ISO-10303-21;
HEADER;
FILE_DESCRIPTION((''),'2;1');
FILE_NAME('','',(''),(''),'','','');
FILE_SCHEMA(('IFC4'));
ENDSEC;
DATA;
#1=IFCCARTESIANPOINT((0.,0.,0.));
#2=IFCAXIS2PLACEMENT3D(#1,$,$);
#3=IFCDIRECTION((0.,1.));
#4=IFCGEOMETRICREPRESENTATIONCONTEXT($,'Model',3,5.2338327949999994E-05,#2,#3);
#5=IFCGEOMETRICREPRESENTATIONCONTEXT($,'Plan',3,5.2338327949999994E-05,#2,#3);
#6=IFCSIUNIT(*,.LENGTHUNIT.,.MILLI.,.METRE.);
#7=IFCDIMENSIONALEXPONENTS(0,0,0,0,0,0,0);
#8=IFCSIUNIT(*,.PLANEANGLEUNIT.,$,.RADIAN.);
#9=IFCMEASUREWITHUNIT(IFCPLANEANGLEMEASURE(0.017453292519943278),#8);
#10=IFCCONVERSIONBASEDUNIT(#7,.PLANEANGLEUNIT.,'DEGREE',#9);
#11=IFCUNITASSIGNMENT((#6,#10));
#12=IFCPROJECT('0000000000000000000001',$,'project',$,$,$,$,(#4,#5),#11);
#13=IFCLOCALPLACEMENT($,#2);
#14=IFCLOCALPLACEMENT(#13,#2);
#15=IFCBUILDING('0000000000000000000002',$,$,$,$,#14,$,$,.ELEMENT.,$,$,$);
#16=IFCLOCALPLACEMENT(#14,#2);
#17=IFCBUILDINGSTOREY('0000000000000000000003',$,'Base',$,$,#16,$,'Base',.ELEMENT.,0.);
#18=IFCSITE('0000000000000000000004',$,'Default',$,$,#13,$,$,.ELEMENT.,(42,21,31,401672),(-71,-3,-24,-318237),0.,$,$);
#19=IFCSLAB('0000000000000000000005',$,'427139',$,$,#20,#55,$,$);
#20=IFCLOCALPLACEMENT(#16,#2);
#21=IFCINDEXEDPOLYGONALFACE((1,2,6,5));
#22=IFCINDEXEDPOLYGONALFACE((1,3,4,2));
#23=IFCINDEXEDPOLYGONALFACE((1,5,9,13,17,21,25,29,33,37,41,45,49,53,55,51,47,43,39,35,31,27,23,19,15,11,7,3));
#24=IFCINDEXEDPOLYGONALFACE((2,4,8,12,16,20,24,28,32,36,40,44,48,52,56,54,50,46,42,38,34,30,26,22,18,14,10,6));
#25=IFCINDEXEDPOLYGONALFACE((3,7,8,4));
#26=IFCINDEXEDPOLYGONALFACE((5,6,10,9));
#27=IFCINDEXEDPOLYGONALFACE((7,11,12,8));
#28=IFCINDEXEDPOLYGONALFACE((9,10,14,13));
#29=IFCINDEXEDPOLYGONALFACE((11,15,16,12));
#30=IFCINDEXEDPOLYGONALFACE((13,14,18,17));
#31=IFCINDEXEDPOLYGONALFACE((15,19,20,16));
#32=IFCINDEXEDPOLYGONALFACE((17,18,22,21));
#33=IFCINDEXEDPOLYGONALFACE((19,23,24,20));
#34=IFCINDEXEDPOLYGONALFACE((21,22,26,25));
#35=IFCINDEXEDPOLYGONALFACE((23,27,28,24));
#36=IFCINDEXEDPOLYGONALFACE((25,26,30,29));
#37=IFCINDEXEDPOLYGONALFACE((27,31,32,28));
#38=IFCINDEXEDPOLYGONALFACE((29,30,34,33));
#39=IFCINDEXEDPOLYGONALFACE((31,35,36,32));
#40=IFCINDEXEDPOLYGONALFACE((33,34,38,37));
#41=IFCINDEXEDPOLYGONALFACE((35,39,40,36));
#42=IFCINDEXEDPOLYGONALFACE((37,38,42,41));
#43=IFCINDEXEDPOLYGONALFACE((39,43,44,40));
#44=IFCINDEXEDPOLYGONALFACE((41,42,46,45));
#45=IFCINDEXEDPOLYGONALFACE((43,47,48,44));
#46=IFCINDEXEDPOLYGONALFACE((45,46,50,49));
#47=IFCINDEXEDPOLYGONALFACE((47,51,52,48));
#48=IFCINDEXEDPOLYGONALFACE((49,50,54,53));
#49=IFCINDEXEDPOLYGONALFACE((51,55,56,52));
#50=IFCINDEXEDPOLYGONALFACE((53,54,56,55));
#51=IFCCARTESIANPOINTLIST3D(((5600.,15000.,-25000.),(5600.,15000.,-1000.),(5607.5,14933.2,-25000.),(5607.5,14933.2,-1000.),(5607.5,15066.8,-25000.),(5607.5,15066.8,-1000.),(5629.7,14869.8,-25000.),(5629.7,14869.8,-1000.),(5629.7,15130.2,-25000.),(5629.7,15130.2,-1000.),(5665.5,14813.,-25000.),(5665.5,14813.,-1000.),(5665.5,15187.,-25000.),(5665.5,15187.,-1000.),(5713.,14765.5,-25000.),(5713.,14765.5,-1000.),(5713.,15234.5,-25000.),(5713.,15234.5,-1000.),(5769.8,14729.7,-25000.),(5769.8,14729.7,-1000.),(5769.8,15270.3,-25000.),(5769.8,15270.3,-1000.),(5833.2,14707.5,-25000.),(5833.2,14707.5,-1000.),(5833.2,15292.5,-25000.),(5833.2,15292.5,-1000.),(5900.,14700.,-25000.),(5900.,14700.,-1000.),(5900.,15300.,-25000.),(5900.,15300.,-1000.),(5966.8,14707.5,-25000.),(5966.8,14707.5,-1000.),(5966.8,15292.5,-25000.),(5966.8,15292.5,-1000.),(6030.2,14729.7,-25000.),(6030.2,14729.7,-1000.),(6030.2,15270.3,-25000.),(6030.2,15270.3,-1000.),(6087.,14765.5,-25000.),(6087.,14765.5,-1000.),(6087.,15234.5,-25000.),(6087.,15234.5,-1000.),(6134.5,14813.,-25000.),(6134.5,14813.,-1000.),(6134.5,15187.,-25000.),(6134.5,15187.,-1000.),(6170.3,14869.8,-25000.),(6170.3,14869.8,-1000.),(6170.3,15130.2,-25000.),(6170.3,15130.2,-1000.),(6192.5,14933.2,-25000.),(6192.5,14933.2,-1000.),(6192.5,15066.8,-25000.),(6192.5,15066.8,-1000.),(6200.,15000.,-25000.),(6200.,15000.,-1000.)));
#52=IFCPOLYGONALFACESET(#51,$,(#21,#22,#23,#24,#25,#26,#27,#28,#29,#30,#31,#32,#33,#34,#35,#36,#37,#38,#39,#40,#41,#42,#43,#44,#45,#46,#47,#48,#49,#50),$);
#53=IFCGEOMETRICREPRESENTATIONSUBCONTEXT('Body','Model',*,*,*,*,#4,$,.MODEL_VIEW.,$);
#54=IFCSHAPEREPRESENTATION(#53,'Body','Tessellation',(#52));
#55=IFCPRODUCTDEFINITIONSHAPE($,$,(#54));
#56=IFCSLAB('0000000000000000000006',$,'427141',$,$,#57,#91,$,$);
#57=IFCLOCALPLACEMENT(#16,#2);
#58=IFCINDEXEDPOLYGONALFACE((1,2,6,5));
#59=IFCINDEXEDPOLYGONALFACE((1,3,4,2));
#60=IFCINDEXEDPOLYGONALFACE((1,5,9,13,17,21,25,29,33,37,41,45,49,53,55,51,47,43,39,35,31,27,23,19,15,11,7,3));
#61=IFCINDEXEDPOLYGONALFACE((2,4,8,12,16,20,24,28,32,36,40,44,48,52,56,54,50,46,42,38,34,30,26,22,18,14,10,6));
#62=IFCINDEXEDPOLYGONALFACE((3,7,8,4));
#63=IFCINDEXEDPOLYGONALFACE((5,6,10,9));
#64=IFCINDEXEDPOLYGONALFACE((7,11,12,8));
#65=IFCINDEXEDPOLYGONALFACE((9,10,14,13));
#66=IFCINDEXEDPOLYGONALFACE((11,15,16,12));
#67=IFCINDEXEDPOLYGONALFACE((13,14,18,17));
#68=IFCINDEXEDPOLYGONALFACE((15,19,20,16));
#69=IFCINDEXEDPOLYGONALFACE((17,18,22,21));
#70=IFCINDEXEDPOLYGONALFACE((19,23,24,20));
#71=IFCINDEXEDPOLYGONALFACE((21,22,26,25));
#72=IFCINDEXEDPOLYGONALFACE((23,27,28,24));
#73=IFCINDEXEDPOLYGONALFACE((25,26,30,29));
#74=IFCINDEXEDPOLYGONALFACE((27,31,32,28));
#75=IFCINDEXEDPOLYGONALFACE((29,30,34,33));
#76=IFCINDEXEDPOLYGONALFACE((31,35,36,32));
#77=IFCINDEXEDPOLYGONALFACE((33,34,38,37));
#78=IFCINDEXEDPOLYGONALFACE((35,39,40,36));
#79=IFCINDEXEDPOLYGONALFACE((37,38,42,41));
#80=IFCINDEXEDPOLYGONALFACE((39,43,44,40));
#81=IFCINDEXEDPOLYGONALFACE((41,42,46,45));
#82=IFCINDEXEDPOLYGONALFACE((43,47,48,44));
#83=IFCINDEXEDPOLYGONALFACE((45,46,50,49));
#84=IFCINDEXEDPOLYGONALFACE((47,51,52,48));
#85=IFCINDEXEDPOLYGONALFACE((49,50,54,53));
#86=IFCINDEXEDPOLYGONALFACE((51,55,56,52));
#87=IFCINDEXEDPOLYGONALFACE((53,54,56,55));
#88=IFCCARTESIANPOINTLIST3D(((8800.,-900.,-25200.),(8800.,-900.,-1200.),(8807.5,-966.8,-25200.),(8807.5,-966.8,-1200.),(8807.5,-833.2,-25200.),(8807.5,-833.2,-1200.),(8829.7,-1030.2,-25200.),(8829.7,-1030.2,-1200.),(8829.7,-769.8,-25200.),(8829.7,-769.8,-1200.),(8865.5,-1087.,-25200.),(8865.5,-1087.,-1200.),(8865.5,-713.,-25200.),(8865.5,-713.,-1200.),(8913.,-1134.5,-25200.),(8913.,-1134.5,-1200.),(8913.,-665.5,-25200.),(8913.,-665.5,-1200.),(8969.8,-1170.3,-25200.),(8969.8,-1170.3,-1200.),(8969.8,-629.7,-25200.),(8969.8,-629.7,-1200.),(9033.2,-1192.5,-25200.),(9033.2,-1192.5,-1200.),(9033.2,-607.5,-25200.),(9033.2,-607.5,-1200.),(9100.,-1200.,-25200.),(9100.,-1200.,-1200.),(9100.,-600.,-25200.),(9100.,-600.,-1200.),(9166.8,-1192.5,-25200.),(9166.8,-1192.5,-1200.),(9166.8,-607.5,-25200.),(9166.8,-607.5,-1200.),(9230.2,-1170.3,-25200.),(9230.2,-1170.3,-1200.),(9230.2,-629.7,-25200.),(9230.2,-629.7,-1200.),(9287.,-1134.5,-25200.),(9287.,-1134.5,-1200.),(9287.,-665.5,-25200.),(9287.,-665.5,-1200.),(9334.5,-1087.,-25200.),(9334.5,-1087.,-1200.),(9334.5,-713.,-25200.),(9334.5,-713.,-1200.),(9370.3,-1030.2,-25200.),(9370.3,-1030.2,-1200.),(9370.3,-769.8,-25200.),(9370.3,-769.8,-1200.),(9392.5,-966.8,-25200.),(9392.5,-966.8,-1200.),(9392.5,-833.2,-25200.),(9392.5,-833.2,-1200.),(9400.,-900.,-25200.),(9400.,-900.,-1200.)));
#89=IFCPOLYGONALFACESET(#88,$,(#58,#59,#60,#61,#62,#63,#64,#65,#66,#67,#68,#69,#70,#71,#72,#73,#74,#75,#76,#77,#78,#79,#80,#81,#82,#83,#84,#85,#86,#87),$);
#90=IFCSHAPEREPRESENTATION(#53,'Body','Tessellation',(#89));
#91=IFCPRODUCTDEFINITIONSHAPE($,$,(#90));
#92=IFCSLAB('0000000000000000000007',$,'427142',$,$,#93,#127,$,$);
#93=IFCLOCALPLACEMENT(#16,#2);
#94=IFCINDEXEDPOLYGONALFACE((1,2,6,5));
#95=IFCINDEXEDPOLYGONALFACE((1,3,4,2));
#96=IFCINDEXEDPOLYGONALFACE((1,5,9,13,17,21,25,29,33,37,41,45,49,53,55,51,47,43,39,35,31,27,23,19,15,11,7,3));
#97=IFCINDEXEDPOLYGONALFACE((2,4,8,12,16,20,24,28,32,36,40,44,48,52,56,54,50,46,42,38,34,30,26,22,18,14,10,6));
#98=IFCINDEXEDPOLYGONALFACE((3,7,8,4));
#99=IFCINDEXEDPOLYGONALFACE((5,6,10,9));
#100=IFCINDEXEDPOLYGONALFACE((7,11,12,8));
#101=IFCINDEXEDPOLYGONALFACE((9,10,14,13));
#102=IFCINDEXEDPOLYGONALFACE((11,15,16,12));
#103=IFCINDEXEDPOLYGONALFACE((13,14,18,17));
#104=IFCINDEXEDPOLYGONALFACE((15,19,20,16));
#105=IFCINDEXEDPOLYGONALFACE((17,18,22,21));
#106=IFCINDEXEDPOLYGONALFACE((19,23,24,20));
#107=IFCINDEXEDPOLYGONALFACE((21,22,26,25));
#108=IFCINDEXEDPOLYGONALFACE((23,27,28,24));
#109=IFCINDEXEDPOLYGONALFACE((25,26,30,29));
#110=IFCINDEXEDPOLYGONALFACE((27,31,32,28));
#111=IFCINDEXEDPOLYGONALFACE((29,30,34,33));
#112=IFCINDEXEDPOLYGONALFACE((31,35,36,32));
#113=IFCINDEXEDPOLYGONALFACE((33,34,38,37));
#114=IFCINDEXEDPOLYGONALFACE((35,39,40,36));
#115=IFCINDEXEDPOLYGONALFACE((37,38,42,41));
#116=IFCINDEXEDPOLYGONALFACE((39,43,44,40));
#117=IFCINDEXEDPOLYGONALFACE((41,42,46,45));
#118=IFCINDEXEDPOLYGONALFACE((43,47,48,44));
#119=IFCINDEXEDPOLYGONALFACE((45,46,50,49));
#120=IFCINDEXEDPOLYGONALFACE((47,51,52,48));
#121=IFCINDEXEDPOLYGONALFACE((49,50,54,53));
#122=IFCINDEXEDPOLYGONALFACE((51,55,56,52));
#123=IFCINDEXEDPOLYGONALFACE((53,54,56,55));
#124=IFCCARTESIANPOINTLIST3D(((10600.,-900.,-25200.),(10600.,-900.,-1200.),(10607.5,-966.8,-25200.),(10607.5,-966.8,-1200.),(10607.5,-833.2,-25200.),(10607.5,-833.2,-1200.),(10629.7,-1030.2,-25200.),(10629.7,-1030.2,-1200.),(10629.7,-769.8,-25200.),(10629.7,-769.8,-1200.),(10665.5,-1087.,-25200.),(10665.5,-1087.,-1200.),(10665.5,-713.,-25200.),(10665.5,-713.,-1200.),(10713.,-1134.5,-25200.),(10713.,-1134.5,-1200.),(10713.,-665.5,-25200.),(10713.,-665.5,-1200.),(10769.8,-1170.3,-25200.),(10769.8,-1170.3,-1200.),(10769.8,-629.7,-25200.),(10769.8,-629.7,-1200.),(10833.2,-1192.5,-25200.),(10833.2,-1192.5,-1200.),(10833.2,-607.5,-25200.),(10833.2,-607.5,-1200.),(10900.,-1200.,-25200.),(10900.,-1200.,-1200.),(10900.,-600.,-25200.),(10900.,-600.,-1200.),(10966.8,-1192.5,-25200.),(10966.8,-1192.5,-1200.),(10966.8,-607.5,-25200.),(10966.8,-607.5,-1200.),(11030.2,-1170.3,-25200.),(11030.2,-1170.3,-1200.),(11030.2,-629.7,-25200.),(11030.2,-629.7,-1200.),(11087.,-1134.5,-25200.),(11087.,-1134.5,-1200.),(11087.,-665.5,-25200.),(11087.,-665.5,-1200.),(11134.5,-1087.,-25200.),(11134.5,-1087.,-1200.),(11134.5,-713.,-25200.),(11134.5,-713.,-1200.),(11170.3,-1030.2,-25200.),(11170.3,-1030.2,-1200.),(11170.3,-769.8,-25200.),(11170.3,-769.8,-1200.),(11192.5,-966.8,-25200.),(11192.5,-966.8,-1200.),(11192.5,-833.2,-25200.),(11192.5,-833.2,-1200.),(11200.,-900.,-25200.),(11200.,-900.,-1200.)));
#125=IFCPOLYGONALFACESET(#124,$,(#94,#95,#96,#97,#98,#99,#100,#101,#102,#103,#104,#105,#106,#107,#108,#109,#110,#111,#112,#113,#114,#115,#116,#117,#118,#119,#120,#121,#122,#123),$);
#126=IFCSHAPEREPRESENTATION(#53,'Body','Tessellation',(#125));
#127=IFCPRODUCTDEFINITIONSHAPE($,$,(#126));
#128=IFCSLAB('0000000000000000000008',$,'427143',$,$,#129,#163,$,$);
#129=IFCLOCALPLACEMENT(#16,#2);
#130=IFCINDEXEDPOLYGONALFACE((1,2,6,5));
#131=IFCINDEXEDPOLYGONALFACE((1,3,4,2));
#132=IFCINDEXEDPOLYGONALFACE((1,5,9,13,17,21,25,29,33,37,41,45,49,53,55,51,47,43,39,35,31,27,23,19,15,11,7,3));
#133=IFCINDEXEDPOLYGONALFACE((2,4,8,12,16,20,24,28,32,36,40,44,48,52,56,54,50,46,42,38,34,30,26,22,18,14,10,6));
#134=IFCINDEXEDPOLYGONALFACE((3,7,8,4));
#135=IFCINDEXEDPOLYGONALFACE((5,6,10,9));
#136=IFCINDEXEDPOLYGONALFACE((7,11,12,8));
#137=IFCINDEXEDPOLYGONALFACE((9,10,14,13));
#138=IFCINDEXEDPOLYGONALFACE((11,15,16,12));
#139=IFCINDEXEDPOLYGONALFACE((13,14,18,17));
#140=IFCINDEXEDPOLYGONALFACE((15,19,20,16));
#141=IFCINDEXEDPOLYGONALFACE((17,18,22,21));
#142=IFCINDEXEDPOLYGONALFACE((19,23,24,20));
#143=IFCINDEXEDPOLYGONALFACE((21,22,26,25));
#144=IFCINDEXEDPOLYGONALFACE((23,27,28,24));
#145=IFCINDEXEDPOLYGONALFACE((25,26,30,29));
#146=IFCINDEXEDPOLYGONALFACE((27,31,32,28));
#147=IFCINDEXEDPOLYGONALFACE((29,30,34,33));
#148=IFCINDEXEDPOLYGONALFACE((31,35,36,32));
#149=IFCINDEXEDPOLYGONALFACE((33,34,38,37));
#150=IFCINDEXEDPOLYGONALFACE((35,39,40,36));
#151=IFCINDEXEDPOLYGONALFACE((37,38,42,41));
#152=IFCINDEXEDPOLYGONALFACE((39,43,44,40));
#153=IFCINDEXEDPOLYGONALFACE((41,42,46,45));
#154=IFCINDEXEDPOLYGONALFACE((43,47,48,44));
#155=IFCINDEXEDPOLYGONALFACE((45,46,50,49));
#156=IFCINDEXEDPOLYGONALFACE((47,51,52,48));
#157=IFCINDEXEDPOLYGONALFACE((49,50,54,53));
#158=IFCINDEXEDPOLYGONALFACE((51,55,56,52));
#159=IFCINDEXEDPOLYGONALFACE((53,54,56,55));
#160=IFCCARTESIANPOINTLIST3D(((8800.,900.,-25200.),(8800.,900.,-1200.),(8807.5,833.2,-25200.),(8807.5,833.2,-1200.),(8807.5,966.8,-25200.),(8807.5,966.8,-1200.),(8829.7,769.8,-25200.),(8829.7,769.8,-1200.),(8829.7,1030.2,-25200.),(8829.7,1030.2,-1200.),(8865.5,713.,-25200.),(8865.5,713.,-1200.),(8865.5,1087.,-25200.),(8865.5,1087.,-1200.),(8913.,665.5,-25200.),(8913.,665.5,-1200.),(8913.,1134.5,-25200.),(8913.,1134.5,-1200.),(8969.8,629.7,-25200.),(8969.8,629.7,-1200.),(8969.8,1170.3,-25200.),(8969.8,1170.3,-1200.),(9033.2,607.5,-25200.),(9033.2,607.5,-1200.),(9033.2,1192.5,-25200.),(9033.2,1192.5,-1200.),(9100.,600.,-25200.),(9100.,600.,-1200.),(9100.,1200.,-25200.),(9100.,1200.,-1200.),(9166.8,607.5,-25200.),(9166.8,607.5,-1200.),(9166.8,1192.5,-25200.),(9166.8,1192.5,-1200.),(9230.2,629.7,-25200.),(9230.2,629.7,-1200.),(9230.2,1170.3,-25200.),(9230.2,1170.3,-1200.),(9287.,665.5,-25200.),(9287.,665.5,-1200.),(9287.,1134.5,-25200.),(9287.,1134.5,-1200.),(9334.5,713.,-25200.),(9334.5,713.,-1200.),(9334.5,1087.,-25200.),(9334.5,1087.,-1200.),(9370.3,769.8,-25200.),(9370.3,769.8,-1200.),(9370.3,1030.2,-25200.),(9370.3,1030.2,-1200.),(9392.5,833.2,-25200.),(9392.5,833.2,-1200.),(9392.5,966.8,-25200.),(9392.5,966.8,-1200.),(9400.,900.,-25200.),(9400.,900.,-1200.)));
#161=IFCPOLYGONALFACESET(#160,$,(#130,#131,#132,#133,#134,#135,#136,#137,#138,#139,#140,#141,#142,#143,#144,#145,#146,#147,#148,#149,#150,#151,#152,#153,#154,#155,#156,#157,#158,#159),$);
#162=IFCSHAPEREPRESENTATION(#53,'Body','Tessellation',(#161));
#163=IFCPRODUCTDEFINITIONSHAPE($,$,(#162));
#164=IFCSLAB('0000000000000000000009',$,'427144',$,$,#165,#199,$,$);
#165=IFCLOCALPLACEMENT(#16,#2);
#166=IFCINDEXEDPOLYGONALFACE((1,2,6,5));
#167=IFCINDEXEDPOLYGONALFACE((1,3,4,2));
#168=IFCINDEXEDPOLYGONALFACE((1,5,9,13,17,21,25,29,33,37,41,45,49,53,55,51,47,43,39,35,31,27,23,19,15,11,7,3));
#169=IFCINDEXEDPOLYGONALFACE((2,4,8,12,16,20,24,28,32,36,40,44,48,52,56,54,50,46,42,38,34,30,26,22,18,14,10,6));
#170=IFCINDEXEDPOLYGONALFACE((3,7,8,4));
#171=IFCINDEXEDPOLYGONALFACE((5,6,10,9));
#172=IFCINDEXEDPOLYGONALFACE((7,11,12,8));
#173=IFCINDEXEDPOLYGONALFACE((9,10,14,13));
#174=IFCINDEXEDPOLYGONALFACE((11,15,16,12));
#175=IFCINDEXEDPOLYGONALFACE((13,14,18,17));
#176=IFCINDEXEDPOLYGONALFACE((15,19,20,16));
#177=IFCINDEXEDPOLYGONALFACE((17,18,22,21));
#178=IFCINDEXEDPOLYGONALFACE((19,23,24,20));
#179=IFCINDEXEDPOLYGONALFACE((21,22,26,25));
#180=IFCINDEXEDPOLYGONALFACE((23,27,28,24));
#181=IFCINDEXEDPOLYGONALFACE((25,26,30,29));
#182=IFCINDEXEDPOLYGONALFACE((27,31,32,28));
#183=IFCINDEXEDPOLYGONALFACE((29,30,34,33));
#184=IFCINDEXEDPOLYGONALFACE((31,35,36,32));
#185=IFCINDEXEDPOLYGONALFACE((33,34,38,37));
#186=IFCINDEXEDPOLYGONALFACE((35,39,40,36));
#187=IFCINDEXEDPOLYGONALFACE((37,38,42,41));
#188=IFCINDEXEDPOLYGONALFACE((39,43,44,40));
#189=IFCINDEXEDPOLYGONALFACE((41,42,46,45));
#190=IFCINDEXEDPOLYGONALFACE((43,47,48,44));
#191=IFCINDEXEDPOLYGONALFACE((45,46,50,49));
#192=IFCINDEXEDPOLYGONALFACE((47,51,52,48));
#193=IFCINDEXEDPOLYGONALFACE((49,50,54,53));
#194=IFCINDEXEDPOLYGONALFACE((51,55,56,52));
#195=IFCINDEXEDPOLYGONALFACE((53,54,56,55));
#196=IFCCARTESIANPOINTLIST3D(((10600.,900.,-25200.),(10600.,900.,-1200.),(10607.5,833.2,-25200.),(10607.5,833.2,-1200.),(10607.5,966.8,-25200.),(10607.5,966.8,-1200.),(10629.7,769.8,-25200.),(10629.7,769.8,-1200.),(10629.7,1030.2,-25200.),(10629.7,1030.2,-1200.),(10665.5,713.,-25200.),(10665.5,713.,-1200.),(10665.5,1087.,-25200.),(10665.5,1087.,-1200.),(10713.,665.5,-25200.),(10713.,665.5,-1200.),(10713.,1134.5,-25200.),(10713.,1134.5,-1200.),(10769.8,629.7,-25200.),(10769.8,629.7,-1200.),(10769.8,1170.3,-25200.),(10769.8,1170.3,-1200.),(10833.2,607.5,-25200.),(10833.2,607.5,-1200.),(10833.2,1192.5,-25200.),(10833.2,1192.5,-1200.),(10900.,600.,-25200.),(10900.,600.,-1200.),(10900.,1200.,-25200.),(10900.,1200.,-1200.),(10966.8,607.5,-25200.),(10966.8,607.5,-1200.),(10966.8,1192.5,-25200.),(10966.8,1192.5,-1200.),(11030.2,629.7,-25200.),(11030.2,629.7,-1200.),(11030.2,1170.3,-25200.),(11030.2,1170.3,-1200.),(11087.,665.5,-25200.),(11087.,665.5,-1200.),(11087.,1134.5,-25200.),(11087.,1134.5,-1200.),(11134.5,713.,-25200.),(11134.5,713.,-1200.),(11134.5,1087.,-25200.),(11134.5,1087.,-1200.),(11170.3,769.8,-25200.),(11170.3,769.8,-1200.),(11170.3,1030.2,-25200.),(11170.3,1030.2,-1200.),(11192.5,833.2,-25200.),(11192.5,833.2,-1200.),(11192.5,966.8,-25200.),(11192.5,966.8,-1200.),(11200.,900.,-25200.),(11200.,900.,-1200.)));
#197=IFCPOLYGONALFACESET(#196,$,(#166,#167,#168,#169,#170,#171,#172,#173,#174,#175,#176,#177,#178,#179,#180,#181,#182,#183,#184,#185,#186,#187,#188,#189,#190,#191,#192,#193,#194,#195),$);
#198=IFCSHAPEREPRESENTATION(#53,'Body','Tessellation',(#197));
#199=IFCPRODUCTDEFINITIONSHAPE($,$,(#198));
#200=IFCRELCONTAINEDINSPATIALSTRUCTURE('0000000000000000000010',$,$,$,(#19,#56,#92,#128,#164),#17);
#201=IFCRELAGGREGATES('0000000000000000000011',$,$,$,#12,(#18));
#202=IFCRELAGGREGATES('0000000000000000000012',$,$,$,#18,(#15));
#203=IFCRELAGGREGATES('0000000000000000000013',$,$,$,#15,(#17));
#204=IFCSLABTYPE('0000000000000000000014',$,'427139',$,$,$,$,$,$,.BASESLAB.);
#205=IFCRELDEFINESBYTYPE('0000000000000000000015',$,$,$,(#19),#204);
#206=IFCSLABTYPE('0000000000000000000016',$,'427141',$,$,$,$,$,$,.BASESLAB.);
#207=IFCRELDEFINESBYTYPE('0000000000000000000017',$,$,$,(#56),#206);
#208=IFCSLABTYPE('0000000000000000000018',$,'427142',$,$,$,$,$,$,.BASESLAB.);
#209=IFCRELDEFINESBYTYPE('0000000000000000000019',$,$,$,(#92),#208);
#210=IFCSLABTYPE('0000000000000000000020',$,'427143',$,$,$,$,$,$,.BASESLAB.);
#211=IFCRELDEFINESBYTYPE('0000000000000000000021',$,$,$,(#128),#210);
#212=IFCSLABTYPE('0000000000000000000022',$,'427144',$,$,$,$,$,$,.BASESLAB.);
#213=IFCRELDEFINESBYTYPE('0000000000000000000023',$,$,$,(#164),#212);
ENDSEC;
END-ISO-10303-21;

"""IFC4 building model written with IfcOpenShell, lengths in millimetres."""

from ifc_helpers import new_model, entity, si_unit, converted_unit, direction, frame, origin, place, context, subcontext, project, spatial, arc, indexed_curve, outline, extrude, type_object, element, save


model = new_model("IFC4")

# Units and contexts
model_context = context("Model", 3, precision=5.2338327949999994e-05, world=origin(), true_north=direction((0.0, 1.0)))
plan_context = context("Plan", 3, precision=5.2338327949999994e-05, world=origin(), true_north=direction((0.0, 1.0)))
body_context = subcontext(model_context, "Body", "Model", "MODEL_VIEW")
ifc_project = project(units=[si_unit("LENGTHUNIT", "METRE", prefix="MILLI"), converted_unit("PLANEANGLEUNIT", "DEGREE", entity("IfcPlaneAngleMeasure", 0.017453292519943278), si_unit("PLANEANGLEUNIT", "RADIAN"), dimensions=[0, 0, 0, 0, 0, 0, 0])], contexts=[model_context, plan_context])

# Site, building, storey
site_placement = place(None, origin())
site = spatial("IfcSite", under=ifc_project, at=site_placement, Name="Default", CompositionType="ELEMENT", RefLatitude=(42, 21, 31, 401672), RefLongitude=(-71, -3, -24, -318237), RefElevation=0.0)
building_placement = place(site_placement, origin())
building = spatial("IfcBuilding", under=site, at=building_placement, CompositionType="ELEMENT")
storey_placement = place(building_placement, origin())
storey = spatial("IfcBuildingStorey", under=building, at=storey_placement, Name="Base", LongName="Base", CompositionType="ELEMENT", Elevation=0.0)

# Slabs
slab_type_1 = type_object("IfcSlabType", Name="427139", PredefinedType="BASESLAB")
slab_1_placement = place(storey_placement, origin())
element("IfcSlab", 1, at=slab_1_placement, inside=storey, type_object=slab_type_1, Name="427139", context=body_context, shape_type="SweptSolid", body=[
    extrude(outline(indexed_curve([(300.0, 0.0), (0.0, 300.0), (-300.0, 0.0), (0.0, -300.0)], segments=[arc(1, 2, 3), arc(3, 4, 1)], self_intersect=False)), frame((5900.0, 15000.0, -25000.0)), (0.0, 0.0, 1.0), 24000.0),
])
slab_type_2 = type_object("IfcSlabType", Name="427141", PredefinedType="BASESLAB")
slab_2_placement = place(storey_placement, origin())
element("IfcSlab", 2, at=slab_2_placement, inside=storey, type_object=slab_type_2, Name="427141", context=body_context, shape_type="SweptSolid", body=[
    extrude(outline(indexed_curve([(300.0, 0.0), (0.0, 300.0), (-300.0, 0.0), (0.0, -300.0)], segments=[arc(1, 2, 3), arc(3, 4, 1)], self_intersect=False)), frame((9100.0, -900.0, -25200.0)), (0.0, 0.0, 1.0), 24000.0),
])
slab_type_3 = type_object("IfcSlabType", Name="427142", PredefinedType="BASESLAB")
slab_3_placement = place(storey_placement, origin())
element("IfcSlab", 3, at=slab_3_placement, inside=storey, type_object=slab_type_3, Name="427142", context=body_context, shape_type="SweptSolid", body=[
    extrude(outline(indexed_curve([(300.0, 0.0), (0.0, 300.0), (-300.0, 0.0), (0.0, -300.0)], segments=[arc(1, 2, 3), arc(3, 4, 1)], self_intersect=False)), frame((10900.0, -900.0, -25200.0)), (0.0, 0.0, 1.0), 24000.0),
])
slab_type_4 = type_object("IfcSlabType", Name="427143", PredefinedType="BASESLAB")
slab_4_placement = place(storey_placement, origin())
element("IfcSlab", 4, at=slab_4_placement, inside=storey, type_object=slab_type_4, Name="427143", context=body_context, shape_type="SweptSolid", body=[
    extrude(outline(indexed_curve([(300.0, 0.0), (0.0, 300.0), (-300.0, 0.0), (0.0, -300.0)], segments=[arc(1, 2, 3), arc(3, 4, 1)], self_intersect=False)), frame((9100.0, 900.0, -25200.0)), (0.0, 0.0, 1.0), 24000.0),
])
slab_type_5 = type_object("IfcSlabType", Name="427144", PredefinedType="BASESLAB")
slab_5_placement = place(storey_placement, origin())
element("IfcSlab", 5, at=slab_5_placement, inside=storey, type_object=slab_type_5, Name="427144", context=body_context, shape_type="SweptSolid", body=[
    extrude(outline(indexed_curve([(300.0, 0.0), (0.0, 300.0), (-300.0, 0.0), (0.0, -300.0)], segments=[arc(1, 2, 3), arc(3, 4, 1)], self_intersect=False)), frame((10900.0, 900.0, -25200.0)), (0.0, 0.0, 1.0), 24000.0),
])

save(model, "model.ifc")
